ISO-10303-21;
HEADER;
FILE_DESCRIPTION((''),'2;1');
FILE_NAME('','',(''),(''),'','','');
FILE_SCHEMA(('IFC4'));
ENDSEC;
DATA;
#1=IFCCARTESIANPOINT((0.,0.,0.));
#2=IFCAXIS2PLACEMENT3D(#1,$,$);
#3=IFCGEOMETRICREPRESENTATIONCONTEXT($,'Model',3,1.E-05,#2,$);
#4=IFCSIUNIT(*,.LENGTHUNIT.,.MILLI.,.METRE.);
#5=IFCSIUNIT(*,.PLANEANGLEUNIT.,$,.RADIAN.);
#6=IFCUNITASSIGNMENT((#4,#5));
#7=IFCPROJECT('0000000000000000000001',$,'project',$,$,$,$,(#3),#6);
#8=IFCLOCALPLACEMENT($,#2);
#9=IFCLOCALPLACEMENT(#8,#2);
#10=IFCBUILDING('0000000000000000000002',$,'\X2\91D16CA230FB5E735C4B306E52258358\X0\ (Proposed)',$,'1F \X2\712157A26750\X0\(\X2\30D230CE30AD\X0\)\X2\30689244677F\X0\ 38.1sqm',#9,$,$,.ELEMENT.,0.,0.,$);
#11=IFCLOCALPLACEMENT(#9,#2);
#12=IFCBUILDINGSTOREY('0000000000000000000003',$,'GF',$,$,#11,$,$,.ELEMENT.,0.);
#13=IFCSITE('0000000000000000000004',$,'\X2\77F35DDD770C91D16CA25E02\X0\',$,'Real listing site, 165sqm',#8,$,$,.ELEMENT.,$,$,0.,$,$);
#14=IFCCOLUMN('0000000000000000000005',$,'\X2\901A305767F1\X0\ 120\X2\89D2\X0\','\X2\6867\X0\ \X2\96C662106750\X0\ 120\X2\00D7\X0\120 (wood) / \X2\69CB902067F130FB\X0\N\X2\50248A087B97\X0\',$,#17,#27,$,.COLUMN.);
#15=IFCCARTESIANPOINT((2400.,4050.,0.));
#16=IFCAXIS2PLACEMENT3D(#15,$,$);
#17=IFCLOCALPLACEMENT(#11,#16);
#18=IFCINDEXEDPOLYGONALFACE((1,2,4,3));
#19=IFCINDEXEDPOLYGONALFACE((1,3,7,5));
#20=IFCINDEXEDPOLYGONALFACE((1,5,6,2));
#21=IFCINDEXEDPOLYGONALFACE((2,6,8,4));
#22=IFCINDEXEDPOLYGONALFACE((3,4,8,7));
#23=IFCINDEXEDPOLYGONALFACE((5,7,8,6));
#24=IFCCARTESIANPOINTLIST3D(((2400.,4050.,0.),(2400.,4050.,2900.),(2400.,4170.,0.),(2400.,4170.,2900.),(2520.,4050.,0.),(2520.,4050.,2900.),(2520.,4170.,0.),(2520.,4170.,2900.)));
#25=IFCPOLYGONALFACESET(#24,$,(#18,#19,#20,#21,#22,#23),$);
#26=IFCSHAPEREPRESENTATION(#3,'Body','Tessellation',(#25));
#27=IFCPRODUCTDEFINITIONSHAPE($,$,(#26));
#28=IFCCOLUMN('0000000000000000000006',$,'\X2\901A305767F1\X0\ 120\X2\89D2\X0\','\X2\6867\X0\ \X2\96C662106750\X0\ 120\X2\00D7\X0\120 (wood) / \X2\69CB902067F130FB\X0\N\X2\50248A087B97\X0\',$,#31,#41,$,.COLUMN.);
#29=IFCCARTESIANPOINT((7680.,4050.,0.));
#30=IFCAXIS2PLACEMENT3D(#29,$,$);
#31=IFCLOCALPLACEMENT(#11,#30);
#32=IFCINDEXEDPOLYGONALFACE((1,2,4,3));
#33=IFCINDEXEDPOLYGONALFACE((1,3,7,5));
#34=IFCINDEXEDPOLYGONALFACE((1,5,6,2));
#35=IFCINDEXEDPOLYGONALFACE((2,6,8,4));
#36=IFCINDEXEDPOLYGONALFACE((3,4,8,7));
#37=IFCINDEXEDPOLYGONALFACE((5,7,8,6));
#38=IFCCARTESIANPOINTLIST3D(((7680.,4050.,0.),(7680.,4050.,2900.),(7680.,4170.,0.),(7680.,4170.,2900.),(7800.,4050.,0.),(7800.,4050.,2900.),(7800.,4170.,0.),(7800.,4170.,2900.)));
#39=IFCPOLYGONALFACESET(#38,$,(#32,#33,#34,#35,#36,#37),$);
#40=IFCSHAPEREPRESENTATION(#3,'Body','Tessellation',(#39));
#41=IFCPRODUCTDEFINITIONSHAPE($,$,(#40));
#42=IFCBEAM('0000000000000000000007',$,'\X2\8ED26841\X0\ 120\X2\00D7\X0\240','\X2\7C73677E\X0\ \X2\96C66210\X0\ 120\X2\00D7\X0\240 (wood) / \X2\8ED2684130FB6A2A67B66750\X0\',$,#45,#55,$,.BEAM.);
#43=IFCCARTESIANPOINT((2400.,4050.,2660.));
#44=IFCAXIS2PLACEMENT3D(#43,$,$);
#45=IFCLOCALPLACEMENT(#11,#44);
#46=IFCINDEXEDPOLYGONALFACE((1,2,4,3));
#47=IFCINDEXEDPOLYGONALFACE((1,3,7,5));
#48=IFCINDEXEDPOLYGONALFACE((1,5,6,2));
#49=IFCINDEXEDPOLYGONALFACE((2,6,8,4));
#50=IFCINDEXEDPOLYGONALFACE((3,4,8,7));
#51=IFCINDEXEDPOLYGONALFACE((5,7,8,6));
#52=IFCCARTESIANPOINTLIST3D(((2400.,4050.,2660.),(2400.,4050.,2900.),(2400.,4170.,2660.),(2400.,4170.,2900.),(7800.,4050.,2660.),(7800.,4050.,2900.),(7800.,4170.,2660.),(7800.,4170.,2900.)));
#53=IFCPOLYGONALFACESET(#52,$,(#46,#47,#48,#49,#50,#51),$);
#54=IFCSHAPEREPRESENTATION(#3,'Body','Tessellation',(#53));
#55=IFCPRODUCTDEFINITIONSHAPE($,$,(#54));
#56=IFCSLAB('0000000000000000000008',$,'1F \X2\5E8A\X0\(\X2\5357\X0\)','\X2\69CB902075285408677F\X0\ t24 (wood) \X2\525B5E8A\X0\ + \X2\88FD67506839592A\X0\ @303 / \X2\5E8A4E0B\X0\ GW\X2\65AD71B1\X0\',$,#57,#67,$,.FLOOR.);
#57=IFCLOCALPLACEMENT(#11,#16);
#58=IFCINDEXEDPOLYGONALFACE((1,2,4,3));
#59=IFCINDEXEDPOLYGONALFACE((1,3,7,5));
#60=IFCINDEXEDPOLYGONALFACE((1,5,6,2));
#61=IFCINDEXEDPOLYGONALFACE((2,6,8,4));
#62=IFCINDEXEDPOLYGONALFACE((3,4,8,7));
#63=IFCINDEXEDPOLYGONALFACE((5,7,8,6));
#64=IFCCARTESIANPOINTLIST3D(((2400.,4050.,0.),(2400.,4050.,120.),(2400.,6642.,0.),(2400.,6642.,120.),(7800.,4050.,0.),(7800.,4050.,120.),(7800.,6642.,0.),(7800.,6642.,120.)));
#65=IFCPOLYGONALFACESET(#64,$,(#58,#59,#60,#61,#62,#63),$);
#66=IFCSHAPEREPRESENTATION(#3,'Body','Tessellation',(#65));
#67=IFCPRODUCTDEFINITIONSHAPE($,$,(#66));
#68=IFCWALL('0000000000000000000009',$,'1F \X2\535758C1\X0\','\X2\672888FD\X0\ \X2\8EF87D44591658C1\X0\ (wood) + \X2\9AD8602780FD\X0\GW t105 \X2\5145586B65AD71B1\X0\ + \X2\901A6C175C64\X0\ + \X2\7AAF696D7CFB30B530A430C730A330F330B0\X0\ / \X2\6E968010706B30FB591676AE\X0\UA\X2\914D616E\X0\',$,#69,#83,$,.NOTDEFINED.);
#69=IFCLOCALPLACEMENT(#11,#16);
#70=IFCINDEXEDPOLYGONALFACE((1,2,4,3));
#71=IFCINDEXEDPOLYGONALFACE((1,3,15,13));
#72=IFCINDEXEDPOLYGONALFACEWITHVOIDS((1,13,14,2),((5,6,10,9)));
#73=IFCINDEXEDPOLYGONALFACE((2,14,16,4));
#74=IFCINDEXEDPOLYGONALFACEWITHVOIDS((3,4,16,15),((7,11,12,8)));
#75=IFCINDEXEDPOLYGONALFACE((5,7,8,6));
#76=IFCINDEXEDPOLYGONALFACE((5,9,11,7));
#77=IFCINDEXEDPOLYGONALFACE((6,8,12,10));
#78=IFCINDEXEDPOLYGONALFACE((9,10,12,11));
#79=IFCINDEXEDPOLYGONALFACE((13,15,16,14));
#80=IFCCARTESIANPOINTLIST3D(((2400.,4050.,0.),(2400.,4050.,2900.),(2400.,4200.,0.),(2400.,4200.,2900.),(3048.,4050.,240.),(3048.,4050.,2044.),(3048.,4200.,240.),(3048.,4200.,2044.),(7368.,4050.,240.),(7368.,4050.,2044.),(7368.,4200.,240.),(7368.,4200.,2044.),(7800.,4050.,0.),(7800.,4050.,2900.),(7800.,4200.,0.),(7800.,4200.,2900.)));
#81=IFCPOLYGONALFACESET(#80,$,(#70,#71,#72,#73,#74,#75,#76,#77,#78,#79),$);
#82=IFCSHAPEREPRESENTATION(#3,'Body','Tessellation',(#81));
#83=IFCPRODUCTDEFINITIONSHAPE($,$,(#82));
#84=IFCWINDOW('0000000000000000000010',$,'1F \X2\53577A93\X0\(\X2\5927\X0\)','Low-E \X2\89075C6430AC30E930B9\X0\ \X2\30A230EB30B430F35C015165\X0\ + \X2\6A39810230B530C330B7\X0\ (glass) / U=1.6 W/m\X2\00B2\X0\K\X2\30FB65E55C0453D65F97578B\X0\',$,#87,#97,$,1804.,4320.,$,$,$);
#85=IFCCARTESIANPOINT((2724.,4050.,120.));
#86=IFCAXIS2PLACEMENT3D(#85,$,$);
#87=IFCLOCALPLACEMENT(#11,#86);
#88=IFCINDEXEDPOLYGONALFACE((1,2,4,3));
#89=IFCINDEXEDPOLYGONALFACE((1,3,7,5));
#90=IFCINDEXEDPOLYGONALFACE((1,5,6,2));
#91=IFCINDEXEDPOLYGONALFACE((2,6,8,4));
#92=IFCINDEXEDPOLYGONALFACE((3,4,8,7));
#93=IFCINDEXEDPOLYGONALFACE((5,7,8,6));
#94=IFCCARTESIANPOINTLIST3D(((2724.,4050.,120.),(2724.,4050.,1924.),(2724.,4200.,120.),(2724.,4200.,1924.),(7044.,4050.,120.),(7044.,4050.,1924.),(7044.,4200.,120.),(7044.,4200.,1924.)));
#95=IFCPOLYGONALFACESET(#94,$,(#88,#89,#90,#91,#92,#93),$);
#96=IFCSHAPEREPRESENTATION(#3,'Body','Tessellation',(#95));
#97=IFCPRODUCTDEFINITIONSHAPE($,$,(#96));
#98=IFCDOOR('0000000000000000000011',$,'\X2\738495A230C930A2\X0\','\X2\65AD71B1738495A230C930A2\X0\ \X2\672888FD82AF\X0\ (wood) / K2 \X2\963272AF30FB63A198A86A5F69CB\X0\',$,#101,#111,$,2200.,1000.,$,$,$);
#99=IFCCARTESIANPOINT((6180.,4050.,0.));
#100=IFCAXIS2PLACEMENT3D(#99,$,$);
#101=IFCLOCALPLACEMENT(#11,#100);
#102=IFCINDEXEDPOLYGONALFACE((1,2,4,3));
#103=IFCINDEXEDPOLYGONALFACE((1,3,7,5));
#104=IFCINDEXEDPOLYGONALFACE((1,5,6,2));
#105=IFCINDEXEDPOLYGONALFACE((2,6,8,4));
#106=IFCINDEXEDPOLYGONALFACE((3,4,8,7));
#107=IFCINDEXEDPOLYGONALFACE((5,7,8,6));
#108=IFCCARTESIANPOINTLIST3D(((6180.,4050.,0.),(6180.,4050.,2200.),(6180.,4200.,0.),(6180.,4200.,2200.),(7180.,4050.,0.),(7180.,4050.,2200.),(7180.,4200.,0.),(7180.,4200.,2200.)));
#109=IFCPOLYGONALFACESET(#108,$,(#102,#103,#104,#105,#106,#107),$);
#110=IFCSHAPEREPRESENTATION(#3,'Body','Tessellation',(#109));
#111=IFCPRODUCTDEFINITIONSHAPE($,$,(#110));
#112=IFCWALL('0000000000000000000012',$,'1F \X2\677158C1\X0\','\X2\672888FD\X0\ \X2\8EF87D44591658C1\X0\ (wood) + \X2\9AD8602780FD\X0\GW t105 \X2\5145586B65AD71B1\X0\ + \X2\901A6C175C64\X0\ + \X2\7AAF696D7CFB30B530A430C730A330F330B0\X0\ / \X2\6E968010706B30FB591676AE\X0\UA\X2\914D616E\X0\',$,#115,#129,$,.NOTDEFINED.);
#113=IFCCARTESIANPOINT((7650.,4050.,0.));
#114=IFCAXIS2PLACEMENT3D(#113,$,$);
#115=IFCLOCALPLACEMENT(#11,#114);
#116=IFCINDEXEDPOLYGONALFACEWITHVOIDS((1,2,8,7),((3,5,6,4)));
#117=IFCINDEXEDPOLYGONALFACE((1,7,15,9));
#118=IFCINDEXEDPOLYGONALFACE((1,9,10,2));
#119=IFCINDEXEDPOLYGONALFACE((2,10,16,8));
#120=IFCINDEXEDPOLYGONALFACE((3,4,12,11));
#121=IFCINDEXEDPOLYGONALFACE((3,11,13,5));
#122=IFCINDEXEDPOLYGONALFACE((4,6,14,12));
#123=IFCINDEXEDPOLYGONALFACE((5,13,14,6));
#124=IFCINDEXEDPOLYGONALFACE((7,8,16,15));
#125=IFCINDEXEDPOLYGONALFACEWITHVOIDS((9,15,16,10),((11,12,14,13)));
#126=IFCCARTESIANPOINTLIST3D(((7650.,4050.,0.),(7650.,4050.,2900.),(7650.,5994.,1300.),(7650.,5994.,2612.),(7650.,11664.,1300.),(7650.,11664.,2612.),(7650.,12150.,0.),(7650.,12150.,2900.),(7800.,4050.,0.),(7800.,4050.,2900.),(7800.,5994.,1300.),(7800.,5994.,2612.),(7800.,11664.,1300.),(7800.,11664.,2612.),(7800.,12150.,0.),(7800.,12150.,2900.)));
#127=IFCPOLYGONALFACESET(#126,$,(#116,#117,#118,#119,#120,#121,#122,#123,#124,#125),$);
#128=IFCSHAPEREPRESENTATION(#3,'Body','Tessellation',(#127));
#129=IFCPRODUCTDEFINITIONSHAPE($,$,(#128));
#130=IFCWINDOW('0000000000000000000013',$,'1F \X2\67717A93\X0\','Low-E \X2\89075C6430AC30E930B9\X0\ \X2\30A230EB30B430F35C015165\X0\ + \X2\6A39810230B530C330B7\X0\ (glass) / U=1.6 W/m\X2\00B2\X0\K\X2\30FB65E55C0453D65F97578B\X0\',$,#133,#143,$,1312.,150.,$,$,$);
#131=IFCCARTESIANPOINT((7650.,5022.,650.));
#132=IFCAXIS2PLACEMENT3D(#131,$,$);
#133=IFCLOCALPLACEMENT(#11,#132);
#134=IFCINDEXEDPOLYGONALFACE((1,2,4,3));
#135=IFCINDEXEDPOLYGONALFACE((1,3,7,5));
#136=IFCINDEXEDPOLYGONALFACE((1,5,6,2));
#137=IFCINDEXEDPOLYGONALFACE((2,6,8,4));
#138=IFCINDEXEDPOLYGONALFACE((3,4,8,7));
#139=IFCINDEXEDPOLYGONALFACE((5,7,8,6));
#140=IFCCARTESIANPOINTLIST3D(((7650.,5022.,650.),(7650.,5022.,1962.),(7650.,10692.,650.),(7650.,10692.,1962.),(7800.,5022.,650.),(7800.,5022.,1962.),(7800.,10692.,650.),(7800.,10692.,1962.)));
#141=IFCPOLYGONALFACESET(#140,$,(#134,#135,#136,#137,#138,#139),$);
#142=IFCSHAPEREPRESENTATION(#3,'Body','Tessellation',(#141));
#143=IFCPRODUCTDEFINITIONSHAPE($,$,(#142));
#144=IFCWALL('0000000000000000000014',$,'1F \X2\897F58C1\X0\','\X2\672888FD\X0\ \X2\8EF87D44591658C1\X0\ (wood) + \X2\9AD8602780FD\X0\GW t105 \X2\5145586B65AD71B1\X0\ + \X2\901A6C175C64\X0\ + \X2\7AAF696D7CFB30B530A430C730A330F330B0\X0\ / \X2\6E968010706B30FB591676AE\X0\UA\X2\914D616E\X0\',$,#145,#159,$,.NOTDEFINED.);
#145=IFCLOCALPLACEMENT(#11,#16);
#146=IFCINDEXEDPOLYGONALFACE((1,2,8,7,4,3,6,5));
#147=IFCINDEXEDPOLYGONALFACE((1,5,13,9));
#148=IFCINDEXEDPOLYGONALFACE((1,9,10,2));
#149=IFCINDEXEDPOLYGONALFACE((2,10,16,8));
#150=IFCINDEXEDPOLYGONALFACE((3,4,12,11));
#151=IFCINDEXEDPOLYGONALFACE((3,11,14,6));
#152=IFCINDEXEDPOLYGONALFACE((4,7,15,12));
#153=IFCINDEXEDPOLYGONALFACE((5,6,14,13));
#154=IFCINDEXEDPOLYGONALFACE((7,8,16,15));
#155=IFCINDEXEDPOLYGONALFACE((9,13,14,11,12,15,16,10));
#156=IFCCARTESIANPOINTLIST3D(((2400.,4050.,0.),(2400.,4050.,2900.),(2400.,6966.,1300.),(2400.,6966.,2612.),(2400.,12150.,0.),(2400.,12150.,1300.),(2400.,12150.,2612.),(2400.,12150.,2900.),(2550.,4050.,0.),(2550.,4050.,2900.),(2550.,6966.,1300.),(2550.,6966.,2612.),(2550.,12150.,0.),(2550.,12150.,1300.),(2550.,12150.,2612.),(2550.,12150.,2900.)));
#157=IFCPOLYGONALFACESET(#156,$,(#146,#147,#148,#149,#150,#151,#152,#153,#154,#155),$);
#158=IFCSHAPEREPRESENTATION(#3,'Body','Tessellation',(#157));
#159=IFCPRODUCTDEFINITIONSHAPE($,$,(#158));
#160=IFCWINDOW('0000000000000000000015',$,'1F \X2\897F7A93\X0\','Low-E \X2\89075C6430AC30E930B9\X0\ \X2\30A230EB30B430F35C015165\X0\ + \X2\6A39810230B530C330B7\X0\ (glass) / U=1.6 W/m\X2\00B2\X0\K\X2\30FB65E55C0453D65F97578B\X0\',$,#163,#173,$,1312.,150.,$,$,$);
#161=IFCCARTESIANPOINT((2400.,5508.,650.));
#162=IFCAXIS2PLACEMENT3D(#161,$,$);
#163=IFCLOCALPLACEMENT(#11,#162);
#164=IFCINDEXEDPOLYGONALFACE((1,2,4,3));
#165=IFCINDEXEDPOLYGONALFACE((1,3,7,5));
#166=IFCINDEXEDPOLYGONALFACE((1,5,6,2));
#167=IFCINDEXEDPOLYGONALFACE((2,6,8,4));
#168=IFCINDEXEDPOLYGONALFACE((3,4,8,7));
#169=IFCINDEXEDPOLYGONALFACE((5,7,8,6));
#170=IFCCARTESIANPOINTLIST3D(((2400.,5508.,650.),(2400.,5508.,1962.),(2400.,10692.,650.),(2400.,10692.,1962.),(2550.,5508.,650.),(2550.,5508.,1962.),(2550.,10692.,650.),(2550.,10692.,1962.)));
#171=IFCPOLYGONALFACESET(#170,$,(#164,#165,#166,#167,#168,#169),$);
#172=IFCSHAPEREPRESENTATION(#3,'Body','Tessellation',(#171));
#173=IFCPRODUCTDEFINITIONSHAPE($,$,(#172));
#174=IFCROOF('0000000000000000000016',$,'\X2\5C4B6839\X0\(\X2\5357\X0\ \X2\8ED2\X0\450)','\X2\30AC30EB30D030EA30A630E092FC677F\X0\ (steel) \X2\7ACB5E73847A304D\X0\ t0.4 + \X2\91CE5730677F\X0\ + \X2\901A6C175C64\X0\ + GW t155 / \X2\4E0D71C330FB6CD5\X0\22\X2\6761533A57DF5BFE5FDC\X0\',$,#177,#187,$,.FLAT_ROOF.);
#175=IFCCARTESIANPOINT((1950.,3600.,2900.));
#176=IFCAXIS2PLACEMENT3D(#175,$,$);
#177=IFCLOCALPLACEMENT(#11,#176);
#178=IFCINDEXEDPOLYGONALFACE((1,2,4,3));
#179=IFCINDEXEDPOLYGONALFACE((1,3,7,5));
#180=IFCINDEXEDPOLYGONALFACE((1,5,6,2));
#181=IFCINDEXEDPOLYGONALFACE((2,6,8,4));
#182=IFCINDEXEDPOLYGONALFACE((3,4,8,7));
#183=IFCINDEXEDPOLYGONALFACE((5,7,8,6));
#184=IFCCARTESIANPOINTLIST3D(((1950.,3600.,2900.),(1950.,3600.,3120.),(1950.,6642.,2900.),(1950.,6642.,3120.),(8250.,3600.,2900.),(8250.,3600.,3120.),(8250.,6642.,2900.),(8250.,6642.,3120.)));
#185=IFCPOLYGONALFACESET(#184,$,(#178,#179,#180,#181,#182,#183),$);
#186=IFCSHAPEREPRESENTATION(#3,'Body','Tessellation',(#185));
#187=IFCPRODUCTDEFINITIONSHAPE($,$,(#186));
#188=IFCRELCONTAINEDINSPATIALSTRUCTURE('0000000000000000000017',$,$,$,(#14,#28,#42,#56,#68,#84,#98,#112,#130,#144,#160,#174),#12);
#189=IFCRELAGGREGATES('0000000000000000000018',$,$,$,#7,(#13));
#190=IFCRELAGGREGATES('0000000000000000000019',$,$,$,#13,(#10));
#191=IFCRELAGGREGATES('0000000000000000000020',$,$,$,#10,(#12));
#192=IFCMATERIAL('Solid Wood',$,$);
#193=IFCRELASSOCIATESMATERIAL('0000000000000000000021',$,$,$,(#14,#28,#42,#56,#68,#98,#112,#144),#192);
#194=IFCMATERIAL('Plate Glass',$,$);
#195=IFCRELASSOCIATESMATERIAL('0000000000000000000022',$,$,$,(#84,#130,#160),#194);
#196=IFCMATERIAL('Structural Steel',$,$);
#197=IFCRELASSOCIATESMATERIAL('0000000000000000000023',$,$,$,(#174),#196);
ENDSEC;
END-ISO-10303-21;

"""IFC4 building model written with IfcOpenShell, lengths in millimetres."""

from ifc_helpers import new_model, si_unit, frame, frame_2d, origin, place, context, project, spatial, rectangle, extrude, material, element, fill, save


model = new_model("IFC4")

# Units and contexts
model_context = context("Model", 3, precision=1e-05, world=origin())
ifc_project = project(units=[si_unit("LENGTHUNIT", "METRE", prefix="MILLI"), si_unit("PLANEANGLEUNIT", "RADIAN")], contexts=[model_context])

# Site, building, storey
site_placement = place(None, origin())
site = spatial("IfcSite", under=ifc_project, at=site_placement, Name="石川県金沢市", ObjectType="Real listing site, 165sqm", CompositionType="ELEMENT", RefElevation=0.0)
building_placement = place(site_placement, origin())
building = spatial("IfcBuilding", under=site, at=building_placement, Name="金沢・平屋の別荘 (Proposed)", ObjectType="1F 無垢材(ヒノキ)と鉄板 38.1sqm", CompositionType="ELEMENT", ElevationOfRefHeight=0.0, ElevationOfTerrain=0.0)
storey_placement = place(building_placement, origin())
storey = spatial("IfcBuildingStorey", under=building, at=storey_placement, Name="GF", CompositionType="ELEMENT", Elevation=0.0)

# Columns
ifc_material_1 = material(Name="Solid Wood")
column_1_placement = place(storey_placement, frame((2400.0, 4050.0, 0.0)))
element("IfcColumn", 1, at=column_1_placement, inside=storey, material=ifc_material_1, Name="通し柱 120角", Description="桧 集成材 120×120 (wood) / 構造柱・N値計算", PredefinedType="COLUMN", context=model_context, shape_type="SweptSolid", body=[
    extrude(rectangle(XDim=120.0, YDim=120.0, at=frame_2d((60.0, 60.0))), frame((2400.0, 4050.0, 0.0)), (0.0, 0.0, 1.0), 2900.0),
])
column_2_placement = place(storey_placement, frame((7680.0, 4050.0, 0.0)))
element("IfcColumn", 2, at=column_2_placement, inside=storey, material=ifc_material_1, Name="通し柱 120角", Description="桧 集成材 120×120 (wood) / 構造柱・N値計算", PredefinedType="COLUMN", context=model_context, shape_type="SweptSolid", body=[
    extrude(rectangle(XDim=120.0, YDim=120.0, at=frame_2d((60.0, 60.0))), frame((7680.0, 4050.0, 0.0)), (0.0, 0.0, 1.0), 2900.0),
])

# Beam
beam_1_placement = place(storey_placement, frame((2400.0, 4050.0, 2660.0)))
element("IfcBeam", 3, at=beam_1_placement, inside=storey, material=ifc_material_1, Name="軒桁 120×240", Description="米松 集成 120×240 (wood) / 軒桁・横架材", PredefinedType="BEAM", context=model_context, shape_type="SweptSolid", body=[
    extrude(rectangle(XDim=5400.0, YDim=120.0, at=frame_2d((2700.0, 60.0))), frame((2400.0, 4050.0, 2660.0)), (0.0, 0.0, 1.0), 240.0),
])

# Slab
slab_1_placement = place(storey_placement, frame((2400.0, 4050.0, 0.0)))
element("IfcSlab", 4, at=slab_1_placement, inside=storey, material=ifc_material_1, Name="1F 床(南)", Description="構造用合板 t24 (wood) 剛床 + 製材根太 @303 / 床下 GW断熱", PredefinedType="FLOOR", context=model_context, shape_type="SweptSolid", body=[
    extrude(rectangle(XDim=5400.0, YDim=2592.0, at=frame_2d((2700.0, 1296.0))), frame((2400.0, 4050.0, 0.0)), (0.0, 0.0, 1.0), 120.0),
])

# Wall, openings, window, door
wall_1_placement = place(storey_placement, frame((2400.0, 4050.0, 0.0)))
wall_1 = element("IfcWall", 5, at=wall_1_placement, inside=storey, material=ifc_material_1, Name="1F 南壁", Description="木製 軸組外壁 (wood) + 高性能GW t105 充填断熱 + 通気層 + 窯業系サイディング / 準耐火・外皮UA配慮", PredefinedType="NOTDEFINED", context=model_context, shape_type="SweptSolid", body=[
    extrude(rectangle(XDim=5400.0, YDim=150.0, at=frame_2d((2700.0, 75.0))), frame((2400.0, 4050.0, 0.0)), (0.0, 0.0, 1.0), 2900.0),
])
opening_1_placement = place(storey_placement, frame((2724.0, 4050.0, 120.0)))
opening_1 = element("IfcOpeningElement", 6, at=opening_1_placement, cuts=wall_1, PredefinedType="NOTDEFINED", context=model_context, shape_type="SweptSolid", body=[
    extrude(rectangle(XDim=4320.0, YDim=150.0, at=frame_2d((2160.0, 75.0))), frame((2724.0, 4050.0, 120.0)), (0.0, 0.0, 1.0), 1804.0),
])
opening_2_placement = place(storey_placement, frame((6180.0, 4050.0, 0.0)))
opening_2 = element("IfcOpeningElement", 7, at=opening_2_placement, cuts=wall_1, PredefinedType="NOTDEFINED", context=model_context, shape_type="SweptSolid", body=[
    extrude(rectangle(XDim=1000.0, YDim=150.0, at=frame_2d((500.0, 75.0))), frame((6180.0, 4050.0, 0.0)), (0.0, 0.0, 1.0), 2200.0),
])
ifc_material_2 = material(Name="Plate Glass")
window_1_placement = place(storey_placement, frame((2724.0, 4050.0, 120.0)))
window_1 = element("IfcWindow", 8, at=window_1_placement, inside=storey, material=ifc_material_2, Name="1F 南窓(大)", Description="Low-E 複層ガラス アルゴン封入 + 樹脂サッシ (glass) / U=1.6 W/m²K・日射取得型", OverallHeight=1804.0, OverallWidth=4320.0, context=model_context, shape_type="SweptSolid", body=[
    extrude(rectangle(XDim=4320.0, YDim=150.0, at=frame_2d((2160.0, 75.0))), frame((2724.0, 4050.0, 120.0)), (0.0, 0.0, 1.0), 1804.0),
])
fill(opening_1, window_1)
door_placement = place(storey_placement, frame((6180.0, 4050.0, 0.0)))
door = element("IfcDoor", 9, at=door_placement, inside=storey, material=ifc_material_1, Name="玄関ドア", Description="断熱玄関ドア 木製芯 (wood) / K2 防犯・採風機構", OverallHeight=2200.0, OverallWidth=1000.0, context=model_context, shape_type="SweptSolid", body=[
    extrude(rectangle(XDim=1000.0, YDim=150.0, at=frame_2d((500.0, 75.0))), frame((6180.0, 4050.0, 0.0)), (0.0, 0.0, 1.0), 2200.0),
])
fill(opening_2, door)

# Walls, openings, windows
wall_2_placement = place(storey_placement, frame((7650.0, 4050.0, 0.0)))
wall_2 = element("IfcWall", 10, at=wall_2_placement, inside=storey, material=ifc_material_1, Name="1F 東壁", Description="木製 軸組外壁 (wood) + 高性能GW t105 充填断熱 + 通気層 + 窯業系サイディング / 準耐火・外皮UA配慮", PredefinedType="NOTDEFINED", context=model_context, shape_type="SweptSolid", body=[
    extrude(rectangle(XDim=150.0, YDim=8100.0, at=frame_2d((75.0, 4050.0))), frame((7650.0, 4050.0, 0.0)), (0.0, 0.0, 1.0), 2900.0),
])
opening_3_placement = place(storey_placement, frame((7650.0, 5022.0, 650.0)))
opening_3 = element("IfcOpeningElement", 11, at=opening_3_placement, cuts=wall_2, PredefinedType="NOTDEFINED", context=model_context, shape_type="SweptSolid", body=[
    extrude(rectangle(XDim=150.0, YDim=5670.0, at=frame_2d((75.0, 2835.0))), frame((7650.0, 5022.0, 650.0)), (0.0, 0.0, 1.0), 1312.0),
])
window_2_placement = place(storey_placement, frame((7650.0, 5022.0, 650.0)))
window_2 = element("IfcWindow", 12, at=window_2_placement, inside=storey, material=ifc_material_2, Name="1F 東窓", Description="Low-E 複層ガラス アルゴン封入 + 樹脂サッシ (glass) / U=1.6 W/m²K・日射取得型", OverallHeight=1312.0, OverallWidth=150.0, context=model_context, shape_type="SweptSolid", body=[
    extrude(rectangle(XDim=150.0, YDim=5670.0, at=frame_2d((75.0, 2835.0))), frame((7650.0, 5022.0, 650.0)), (0.0, 0.0, 1.0), 1312.0),
])
fill(opening_3, window_2)
wall_3_placement = place(storey_placement, frame((2400.0, 4050.0, 0.0)))
wall_3 = element("IfcWall", 13, at=wall_3_placement, inside=storey, material=ifc_material_1, Name="1F 西壁", Description="木製 軸組外壁 (wood) + 高性能GW t105 充填断熱 + 通気層 + 窯業系サイディング / 準耐火・外皮UA配慮", PredefinedType="NOTDEFINED", context=model_context, shape_type="SweptSolid", body=[
    extrude(rectangle(XDim=150.0, YDim=8100.0, at=frame_2d((75.0, 4050.0))), frame((2400.0, 4050.0, 0.0)), (0.0, 0.0, 1.0), 2900.0),
])
opening_4_placement = place(storey_placement, frame((2400.0, 5508.0, 650.0)))
opening_4 = element("IfcOpeningElement", 14, at=opening_4_placement, cuts=wall_3, PredefinedType="NOTDEFINED", context=model_context, shape_type="SweptSolid", body=[
    extrude(rectangle(XDim=150.0, YDim=5184.0, at=frame_2d((75.0, 2592.0))), frame((2400.0, 5508.0, 650.0)), (0.0, 0.0, 1.0), 1312.0),
])
window_3_placement = place(storey_placement, frame((2400.0, 5508.0, 650.0)))
window_3 = element("IfcWindow", 15, at=window_3_placement, inside=storey, material=ifc_material_2, Name="1F 西窓", Description="Low-E 複層ガラス アルゴン封入 + 樹脂サッシ (glass) / U=1.6 W/m²K・日射取得型", OverallHeight=1312.0, OverallWidth=150.0, context=model_context, shape_type="SweptSolid", body=[
    extrude(rectangle(XDim=150.0, YDim=5184.0, at=frame_2d((75.0, 2592.0))), frame((2400.0, 5508.0, 650.0)), (0.0, 0.0, 1.0), 1312.0),
])
fill(opening_4, window_3)

# Roof
ifc_material_3 = material(Name="Structural Steel")
roof_placement = place(storey_placement, frame((1950.0, 3600.0, 2900.0)))
element("IfcRoof", 16, at=roof_placement, inside=storey, material=ifc_material_3, Name="屋根(南 軒450)", Description="ガルバリウム鋼板 (steel) 立平葺き t0.4 + 野地板 + 通気層 + GW t155 / 不燃・法22条区域対応", PredefinedType="FLAT_ROOF", context=model_context, shape_type="SweptSolid", body=[
    extrude(rectangle(XDim=6300.0, YDim=3042.0, at=frame_2d((3150.0, 1521.0))), frame((1950.0, 3600.0, 2900.0)), (0.0, 0.0, 1.0), 220.0),
])

save(model, "model.ifc")
